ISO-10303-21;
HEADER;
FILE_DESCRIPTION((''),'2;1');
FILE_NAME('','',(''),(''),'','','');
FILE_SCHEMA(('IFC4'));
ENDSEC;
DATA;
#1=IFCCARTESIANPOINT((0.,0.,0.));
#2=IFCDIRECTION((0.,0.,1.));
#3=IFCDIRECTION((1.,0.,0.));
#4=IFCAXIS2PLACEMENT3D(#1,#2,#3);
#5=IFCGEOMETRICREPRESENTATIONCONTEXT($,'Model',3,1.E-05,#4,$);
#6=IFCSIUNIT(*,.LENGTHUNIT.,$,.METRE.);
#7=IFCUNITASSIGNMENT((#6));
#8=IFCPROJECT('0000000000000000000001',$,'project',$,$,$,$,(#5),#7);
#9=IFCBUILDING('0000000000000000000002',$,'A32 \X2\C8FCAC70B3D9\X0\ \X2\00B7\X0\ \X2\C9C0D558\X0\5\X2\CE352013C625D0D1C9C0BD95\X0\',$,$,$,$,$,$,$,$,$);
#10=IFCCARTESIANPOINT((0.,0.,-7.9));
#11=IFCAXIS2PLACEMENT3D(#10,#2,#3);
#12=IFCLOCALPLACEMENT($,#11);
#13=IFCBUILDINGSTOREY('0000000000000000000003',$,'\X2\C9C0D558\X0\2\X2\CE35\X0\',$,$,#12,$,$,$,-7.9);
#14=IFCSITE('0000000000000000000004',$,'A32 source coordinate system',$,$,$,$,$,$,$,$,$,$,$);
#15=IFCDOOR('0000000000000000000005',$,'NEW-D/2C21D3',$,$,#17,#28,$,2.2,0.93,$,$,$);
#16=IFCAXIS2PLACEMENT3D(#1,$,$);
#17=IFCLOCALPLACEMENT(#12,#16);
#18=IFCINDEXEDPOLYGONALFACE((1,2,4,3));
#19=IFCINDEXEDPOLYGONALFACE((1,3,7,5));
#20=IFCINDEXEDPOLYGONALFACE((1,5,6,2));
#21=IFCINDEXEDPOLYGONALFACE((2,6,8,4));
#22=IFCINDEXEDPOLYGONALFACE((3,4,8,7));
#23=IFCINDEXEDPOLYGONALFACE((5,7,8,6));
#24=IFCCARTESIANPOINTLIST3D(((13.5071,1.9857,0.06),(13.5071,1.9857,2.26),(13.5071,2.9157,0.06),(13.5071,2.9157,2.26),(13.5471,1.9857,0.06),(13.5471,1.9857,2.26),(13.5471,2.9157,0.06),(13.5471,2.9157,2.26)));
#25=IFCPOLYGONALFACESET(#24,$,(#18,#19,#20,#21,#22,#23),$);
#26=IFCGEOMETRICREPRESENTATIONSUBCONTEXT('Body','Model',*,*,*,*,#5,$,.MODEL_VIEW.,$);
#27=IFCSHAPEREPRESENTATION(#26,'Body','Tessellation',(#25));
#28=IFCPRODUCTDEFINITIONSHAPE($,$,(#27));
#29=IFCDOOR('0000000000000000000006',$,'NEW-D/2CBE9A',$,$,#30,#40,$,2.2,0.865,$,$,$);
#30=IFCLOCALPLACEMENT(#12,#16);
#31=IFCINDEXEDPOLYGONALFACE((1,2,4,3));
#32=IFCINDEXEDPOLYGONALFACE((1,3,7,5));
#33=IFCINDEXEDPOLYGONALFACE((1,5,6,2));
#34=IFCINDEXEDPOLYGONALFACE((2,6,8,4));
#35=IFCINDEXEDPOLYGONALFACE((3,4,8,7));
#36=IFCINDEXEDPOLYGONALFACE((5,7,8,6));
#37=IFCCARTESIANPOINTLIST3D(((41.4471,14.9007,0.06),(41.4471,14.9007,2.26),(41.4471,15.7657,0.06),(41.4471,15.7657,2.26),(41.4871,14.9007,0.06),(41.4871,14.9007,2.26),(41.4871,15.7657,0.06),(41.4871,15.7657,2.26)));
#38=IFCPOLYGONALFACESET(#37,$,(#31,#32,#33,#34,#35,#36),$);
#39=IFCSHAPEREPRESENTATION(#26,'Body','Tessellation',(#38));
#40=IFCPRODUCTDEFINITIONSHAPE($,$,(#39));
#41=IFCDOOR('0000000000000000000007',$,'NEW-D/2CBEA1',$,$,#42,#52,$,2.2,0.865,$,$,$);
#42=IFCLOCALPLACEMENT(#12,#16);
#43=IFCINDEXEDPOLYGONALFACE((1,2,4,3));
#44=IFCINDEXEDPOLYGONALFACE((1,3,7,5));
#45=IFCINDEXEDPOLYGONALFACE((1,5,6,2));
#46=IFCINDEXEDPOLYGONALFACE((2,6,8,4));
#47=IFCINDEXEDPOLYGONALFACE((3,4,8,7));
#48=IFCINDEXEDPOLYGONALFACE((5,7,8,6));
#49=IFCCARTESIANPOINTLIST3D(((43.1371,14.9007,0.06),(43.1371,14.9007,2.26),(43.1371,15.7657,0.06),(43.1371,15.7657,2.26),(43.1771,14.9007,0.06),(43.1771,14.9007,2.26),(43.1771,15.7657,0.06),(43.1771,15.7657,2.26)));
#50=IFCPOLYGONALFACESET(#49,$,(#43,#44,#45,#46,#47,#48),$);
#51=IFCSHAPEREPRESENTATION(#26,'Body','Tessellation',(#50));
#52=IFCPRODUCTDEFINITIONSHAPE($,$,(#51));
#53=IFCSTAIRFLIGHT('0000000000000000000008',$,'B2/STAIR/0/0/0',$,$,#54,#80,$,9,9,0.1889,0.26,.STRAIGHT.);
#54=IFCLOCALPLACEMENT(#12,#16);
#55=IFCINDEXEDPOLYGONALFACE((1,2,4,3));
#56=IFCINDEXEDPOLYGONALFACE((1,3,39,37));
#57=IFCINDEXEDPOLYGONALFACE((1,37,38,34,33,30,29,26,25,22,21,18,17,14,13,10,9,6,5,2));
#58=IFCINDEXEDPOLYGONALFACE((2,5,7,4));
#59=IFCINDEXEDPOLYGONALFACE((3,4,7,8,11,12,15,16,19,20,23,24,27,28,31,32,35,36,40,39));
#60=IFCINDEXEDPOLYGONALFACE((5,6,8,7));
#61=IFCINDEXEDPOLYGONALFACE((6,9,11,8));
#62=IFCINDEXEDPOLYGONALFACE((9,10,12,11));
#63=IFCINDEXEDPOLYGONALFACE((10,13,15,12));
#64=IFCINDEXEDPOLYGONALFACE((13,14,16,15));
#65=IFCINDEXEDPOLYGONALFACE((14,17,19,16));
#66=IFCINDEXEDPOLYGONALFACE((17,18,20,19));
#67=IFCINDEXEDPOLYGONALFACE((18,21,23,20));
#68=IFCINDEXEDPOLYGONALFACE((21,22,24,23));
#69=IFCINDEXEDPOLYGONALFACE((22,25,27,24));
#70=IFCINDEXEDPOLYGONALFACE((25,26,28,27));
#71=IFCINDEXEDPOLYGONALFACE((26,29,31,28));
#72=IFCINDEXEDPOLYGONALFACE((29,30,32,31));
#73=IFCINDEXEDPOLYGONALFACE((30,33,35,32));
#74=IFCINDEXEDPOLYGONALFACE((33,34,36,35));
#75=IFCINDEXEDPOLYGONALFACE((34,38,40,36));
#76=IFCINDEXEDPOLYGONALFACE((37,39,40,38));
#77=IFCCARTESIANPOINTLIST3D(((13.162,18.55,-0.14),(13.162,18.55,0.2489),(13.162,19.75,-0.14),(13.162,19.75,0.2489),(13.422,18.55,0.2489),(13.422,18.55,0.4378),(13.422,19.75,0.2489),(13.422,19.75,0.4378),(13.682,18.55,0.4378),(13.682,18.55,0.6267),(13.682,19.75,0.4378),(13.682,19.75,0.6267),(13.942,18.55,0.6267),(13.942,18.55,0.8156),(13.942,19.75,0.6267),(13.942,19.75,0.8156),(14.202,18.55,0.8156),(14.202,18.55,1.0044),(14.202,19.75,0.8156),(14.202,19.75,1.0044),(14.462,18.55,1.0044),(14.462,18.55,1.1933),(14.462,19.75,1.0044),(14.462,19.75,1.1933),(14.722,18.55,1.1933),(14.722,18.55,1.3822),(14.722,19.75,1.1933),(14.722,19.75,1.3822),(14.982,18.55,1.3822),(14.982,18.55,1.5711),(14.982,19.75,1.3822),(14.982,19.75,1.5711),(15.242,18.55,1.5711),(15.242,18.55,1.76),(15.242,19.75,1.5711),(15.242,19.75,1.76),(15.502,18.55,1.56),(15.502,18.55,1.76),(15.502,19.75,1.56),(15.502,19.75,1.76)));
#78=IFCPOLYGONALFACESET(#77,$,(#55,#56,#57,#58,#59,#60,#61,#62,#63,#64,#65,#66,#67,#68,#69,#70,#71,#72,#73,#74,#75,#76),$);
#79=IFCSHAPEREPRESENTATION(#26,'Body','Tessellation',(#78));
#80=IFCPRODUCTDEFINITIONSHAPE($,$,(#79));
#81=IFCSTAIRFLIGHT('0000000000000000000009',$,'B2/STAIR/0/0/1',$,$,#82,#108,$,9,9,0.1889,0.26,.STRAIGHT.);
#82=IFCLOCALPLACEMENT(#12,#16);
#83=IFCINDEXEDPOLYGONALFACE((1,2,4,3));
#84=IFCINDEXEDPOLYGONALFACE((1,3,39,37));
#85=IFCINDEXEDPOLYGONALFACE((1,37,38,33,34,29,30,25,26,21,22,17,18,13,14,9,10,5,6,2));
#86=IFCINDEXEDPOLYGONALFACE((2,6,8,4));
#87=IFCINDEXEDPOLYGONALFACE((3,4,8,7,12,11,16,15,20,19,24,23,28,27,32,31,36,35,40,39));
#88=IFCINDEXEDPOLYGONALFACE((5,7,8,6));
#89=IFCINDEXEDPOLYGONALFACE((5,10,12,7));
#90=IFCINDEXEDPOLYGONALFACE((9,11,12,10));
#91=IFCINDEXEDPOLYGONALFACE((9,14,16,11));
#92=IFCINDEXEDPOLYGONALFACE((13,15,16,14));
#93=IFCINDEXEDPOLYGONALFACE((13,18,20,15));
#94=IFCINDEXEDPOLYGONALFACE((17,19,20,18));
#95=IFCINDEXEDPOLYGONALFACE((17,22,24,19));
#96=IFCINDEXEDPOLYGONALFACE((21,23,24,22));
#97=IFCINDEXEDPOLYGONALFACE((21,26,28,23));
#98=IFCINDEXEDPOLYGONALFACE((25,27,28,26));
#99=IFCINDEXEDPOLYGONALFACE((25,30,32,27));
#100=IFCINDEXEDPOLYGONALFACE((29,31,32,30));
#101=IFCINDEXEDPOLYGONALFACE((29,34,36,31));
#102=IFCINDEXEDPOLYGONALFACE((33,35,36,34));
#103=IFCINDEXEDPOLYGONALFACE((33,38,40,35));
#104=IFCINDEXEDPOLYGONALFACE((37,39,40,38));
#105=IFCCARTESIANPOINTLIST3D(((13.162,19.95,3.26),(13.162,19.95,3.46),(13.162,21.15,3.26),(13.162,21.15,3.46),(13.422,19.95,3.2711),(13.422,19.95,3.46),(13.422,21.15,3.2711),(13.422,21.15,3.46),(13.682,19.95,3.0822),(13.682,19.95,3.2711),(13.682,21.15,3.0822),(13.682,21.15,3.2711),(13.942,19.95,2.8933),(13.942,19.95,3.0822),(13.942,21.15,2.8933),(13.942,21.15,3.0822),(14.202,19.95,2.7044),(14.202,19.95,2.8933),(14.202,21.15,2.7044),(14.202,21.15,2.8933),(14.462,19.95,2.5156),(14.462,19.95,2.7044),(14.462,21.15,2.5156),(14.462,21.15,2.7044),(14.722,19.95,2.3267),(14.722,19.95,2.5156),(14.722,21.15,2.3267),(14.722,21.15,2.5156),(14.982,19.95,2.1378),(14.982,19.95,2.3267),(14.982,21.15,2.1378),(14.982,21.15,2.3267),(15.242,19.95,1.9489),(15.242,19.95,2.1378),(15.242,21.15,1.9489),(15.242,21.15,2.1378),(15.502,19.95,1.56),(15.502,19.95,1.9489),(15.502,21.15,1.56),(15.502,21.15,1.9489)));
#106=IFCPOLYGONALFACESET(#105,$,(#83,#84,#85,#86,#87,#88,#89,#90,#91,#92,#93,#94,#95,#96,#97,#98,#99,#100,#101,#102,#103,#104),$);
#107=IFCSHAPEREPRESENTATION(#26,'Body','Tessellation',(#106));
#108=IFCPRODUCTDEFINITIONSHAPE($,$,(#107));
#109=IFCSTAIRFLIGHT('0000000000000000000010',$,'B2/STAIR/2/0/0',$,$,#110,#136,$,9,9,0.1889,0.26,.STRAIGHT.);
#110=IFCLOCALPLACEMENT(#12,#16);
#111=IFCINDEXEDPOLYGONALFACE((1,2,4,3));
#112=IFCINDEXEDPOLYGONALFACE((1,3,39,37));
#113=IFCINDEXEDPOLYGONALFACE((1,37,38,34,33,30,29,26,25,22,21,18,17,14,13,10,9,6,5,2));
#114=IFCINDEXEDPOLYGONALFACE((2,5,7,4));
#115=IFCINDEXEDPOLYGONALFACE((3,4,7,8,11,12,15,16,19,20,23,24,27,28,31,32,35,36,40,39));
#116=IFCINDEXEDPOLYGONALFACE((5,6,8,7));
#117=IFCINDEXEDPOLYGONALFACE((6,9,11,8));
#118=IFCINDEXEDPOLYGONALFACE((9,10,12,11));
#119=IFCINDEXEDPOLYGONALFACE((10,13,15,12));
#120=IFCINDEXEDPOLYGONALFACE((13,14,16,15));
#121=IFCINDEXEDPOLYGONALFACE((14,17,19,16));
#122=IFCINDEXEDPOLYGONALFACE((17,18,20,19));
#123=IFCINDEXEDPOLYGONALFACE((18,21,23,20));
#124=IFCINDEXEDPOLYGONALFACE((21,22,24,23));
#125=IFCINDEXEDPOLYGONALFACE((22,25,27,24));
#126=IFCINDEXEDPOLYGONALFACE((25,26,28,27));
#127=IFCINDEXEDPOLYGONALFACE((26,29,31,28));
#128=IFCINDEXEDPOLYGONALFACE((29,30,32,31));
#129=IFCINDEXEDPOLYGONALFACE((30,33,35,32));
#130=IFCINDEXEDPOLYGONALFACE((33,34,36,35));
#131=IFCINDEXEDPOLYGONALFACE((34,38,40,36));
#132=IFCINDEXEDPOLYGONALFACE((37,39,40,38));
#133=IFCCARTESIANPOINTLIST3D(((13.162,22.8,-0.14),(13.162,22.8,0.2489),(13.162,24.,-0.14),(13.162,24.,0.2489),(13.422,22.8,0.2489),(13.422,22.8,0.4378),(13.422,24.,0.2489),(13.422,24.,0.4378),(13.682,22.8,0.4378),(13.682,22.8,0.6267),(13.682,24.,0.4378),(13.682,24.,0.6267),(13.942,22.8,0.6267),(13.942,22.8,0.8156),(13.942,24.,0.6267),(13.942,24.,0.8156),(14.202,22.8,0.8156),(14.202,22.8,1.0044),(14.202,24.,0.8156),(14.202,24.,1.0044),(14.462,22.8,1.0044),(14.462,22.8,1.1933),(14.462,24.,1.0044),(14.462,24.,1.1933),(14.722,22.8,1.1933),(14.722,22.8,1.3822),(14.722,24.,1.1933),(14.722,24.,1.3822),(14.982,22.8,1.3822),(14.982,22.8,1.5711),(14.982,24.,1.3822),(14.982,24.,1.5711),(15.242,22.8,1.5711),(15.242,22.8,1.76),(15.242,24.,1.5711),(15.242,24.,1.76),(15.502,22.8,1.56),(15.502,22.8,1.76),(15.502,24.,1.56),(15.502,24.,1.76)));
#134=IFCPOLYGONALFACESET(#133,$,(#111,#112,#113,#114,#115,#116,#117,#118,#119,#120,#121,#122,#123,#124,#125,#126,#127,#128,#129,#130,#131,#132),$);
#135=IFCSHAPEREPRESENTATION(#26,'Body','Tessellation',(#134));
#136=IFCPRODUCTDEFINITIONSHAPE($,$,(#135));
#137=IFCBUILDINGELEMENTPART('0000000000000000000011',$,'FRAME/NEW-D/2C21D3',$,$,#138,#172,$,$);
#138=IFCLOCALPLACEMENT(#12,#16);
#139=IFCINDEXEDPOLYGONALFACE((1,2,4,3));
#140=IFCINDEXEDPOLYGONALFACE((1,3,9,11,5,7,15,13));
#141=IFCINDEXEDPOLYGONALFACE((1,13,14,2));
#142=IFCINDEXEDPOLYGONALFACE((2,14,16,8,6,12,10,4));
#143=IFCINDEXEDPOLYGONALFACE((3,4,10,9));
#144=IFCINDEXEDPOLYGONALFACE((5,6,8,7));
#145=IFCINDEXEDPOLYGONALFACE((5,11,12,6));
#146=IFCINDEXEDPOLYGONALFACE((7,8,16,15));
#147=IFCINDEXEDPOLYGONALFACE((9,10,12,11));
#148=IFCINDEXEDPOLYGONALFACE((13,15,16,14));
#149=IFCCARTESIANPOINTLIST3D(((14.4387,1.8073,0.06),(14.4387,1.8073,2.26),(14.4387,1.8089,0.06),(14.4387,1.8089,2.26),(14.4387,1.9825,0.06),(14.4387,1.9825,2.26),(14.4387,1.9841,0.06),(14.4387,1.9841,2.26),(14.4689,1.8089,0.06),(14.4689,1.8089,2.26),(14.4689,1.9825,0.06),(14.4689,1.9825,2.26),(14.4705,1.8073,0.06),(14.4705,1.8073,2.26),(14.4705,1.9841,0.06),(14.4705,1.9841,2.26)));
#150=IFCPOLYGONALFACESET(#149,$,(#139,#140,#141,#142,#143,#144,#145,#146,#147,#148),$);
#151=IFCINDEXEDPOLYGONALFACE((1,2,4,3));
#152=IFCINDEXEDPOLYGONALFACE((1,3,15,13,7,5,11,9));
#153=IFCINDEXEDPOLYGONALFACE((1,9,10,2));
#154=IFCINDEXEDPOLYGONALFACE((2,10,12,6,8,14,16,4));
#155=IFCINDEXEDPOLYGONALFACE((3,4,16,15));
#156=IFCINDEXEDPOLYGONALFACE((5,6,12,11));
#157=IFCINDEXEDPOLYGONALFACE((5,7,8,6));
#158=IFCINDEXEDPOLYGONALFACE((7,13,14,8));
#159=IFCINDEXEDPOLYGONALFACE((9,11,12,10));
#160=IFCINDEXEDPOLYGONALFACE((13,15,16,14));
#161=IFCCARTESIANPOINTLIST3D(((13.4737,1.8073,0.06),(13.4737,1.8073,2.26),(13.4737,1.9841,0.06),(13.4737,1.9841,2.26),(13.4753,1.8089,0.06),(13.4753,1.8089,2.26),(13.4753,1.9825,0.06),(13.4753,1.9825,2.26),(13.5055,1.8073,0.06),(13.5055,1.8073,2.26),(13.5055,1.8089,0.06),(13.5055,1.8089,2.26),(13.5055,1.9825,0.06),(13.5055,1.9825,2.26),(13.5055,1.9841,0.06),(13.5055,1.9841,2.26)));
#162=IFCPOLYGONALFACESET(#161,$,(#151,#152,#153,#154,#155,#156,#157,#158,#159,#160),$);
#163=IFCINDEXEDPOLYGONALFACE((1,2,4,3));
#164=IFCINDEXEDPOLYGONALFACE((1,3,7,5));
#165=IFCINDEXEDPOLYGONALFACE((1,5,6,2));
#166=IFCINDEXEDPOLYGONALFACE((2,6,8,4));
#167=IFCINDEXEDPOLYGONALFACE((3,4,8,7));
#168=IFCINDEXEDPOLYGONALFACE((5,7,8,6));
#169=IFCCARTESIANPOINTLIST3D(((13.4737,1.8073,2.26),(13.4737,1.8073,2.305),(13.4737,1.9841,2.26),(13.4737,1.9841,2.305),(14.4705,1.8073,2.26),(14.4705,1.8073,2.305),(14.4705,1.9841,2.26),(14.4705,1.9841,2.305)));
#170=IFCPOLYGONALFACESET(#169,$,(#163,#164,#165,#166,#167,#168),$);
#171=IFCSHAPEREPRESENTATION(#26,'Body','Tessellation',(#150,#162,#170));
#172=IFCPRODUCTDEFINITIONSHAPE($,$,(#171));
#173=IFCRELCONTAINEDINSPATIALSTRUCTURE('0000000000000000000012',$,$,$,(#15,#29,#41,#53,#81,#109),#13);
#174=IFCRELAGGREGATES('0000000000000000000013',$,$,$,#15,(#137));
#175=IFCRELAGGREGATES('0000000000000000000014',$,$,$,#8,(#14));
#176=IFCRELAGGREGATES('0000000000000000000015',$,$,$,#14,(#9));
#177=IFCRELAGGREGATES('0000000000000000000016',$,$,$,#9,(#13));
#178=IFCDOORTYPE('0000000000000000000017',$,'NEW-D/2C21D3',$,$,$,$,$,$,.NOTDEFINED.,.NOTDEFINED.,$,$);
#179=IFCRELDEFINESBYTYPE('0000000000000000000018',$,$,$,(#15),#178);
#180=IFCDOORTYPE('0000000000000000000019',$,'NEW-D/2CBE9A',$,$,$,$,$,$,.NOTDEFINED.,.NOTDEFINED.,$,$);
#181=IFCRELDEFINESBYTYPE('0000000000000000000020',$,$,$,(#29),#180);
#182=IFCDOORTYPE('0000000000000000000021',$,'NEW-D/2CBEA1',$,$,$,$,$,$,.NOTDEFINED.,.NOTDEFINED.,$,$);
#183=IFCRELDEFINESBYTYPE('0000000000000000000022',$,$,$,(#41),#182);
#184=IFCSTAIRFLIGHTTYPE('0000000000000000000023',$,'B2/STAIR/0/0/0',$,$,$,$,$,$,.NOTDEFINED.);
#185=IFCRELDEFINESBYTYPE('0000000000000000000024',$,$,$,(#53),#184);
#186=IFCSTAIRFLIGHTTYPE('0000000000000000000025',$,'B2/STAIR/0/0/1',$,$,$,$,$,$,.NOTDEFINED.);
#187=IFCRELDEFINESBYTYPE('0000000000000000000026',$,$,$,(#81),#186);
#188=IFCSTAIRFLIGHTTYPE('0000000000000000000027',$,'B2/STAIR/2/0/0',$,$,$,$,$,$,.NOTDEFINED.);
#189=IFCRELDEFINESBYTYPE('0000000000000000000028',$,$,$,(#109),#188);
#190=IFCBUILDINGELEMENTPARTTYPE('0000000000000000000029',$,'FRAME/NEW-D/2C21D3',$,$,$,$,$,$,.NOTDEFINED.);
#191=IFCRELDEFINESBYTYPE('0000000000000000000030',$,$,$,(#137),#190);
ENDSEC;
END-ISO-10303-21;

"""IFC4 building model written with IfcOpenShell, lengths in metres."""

from ifc_helpers import new_model, si_unit, frame, origin, origin_with_axes, place, context, subcontext, project, spatial, polyline, outline, extrude, source, transform, mapped, type_object, type_shapes, element, aggregate, save


model = new_model("IFC4")

# Units and contexts
model_context = context("Model", 3, precision=1e-05, world=origin_with_axes())
body_context = subcontext(model_context, "Body", "Model", "MODEL_VIEW")
ifc_project = project(units=[si_unit("LENGTHUNIT", "METRE")], contexts=[model_context])

# Site, building, storey
site = spatial("IfcSite", under=ifc_project, Name="A32 source coordinate system")
building = spatial("IfcBuilding", under=site, Name="A32 주거동 · 지하5층–옥탑지붕")
storey_placement = place(None, frame((0.0, 0.0, -7.9), z_axis=(0.0, 0.0, 1.0), x_axis=(1.0, 0.0, 0.0)))
storey = spatial("IfcBuildingStorey", under=building, at=storey_placement, Name="지하2층", Elevation=-7.9)

# Door
door_type_1 = type_object("IfcDoorType", Name="NEW-D/2C21D3", OperationType="NOTDEFINED", PredefinedType="NOTDEFINED")
shared_shape_1 = source(origin(), body_context, "Body", "SweptSolid", [
    extrude(outline(polyline([(13.5471, 2.9157), (13.5471, 1.9857), (13.5071, 1.9857), (13.5071, 2.9157), (13.5471, 2.9157)])), frame((0.0, 0.0, 0.06)), (0.0, 0.0, 1.0), 2.2),
])
type_shapes(door_type_1, [shared_shape_1])
door_1_placement = place(storey_placement, origin_with_axes())
door_1 = element("IfcDoor", 1, at=door_1_placement, inside=storey, type_object=door_type_1, Name="NEW-D/2C21D3", OverallHeight=2.2, OverallWidth=0.93, context=body_context, shape_type="MappedRepresentation", body=[
    mapped(shared_shape_1, transform((0.0, 0.0, 0.0), scale=1.0)),
])

# Doors
door_type_2 = type_object("IfcDoorType", Name="NEW-D/2CBE9A", OperationType="NOTDEFINED", PredefinedType="NOTDEFINED")
shared_shape_2 = source(origin(), body_context, "Body", "SweptSolid", [
    extrude(outline(polyline([(41.4871, 14.9007), (41.4471, 14.9007), (41.4471, 15.7657), (41.4871, 15.7657), (41.4871, 14.9007)])), frame((0.0, 0.0, 0.06)), (0.0, 0.0, 1.0), 2.2),
])
type_shapes(door_type_2, [shared_shape_2])
door_2_placement = place(storey_placement, origin_with_axes())
element("IfcDoor", 2, at=door_2_placement, inside=storey, type_object=door_type_2, Name="NEW-D/2CBE9A", OverallHeight=2.2, OverallWidth=0.865, context=body_context, shape_type="MappedRepresentation", body=[
    mapped(shared_shape_2, transform((0.0, 0.0, 0.0), scale=1.0)),
])
door_type_3 = type_object("IfcDoorType", Name="NEW-D/2CBEA1", OperationType="NOTDEFINED", PredefinedType="NOTDEFINED")
shared_shape_3 = source(origin(), body_context, "Body", "SweptSolid", [
    extrude(outline(polyline([(43.1771, 15.7657), (43.1771, 14.9007), (43.1371, 14.9007), (43.1371, 15.7657), (43.1771, 15.7657)])), frame((0.0, 0.0, 0.06)), (0.0, 0.0, 1.0), 2.2),
])
type_shapes(door_type_3, [shared_shape_3])
door_3_placement = place(storey_placement, origin_with_axes())
element("IfcDoor", 3, at=door_3_placement, inside=storey, type_object=door_type_3, Name="NEW-D/2CBEA1", OverallHeight=2.2, OverallWidth=0.865, context=body_context, shape_type="MappedRepresentation", body=[
    mapped(shared_shape_3, transform((0.0, 0.0, 0.0), scale=1.0)),
])

# Stair flights
stair_flight_type_1 = type_object("IfcStairFlightType", Name="B2/STAIR/0/0/0", PredefinedType="NOTDEFINED")
shared_shape_4 = source(origin(), body_context, "Body", "SweptSolid", [
    extrude(outline(polyline([(0.0, -0.14), (2.34, 1.56), (2.34, 1.76), (2.08, 1.76), (2.08, 1.5711), (1.82, 1.5711), (1.82, 1.3822), (1.56, 1.3822), (1.56, 1.1933), (1.3, 1.1933), (1.3, 1.0044), (1.04, 1.0044), (1.04, 0.8156), (0.78, 0.8156), (0.78, 0.6267), (0.52, 0.6267), (0.52, 0.4378), (0.26, 0.4378), (0.26, 0.2489), (0.0, 0.2489), (0.0, -0.14)])), frame((13.162, 19.75, 0.0), z_axis=(0.0, -1.0, 0.0), x_axis=(1.0, 0.0, 0.0)), (0.0, 0.0, 1.0), 1.2),
])
type_shapes(stair_flight_type_1, [shared_shape_4])
stair_flight_1_placement = place(storey_placement, origin_with_axes())
element("IfcStairFlight", 4, at=stair_flight_1_placement, inside=storey, type_object=stair_flight_type_1, Name="B2/STAIR/0/0/0", NumberOfRisers=9, NumberOfTreads=9, PredefinedType="STRAIGHT", RiserHeight=0.1889, TreadLength=0.26, context=body_context, shape_type="MappedRepresentation", body=[
    mapped(shared_shape_4, transform((0.0, 0.0, 0.0), scale=1.0)),
])
stair_flight_type_2 = type_object("IfcStairFlightType", Name="B2/STAIR/0/0/1", PredefinedType="NOTDEFINED")
shared_shape_5 = source(origin(), body_context, "Body", "SweptSolid", [
    extrude(outline(polyline([(0.0, 1.56), (2.34, 3.26), (2.34, 3.46), (2.08, 3.46), (2.08, 3.2711), (1.82, 3.2711), (1.82, 3.0822), (1.56, 3.0822), (1.56, 2.8933), (1.3, 2.8933), (1.3, 2.7044), (1.04, 2.7044), (1.04, 2.5156), (0.78, 2.5156), (0.78, 2.3267), (0.52, 2.3267), (0.52, 2.1378), (0.26, 2.1378), (0.26, 1.9489), (0.0, 1.9489), (0.0, 1.56)])), frame((15.502, 19.95, 0.0), z_axis=(0.0, 1.0, 0.0), x_axis=(-1.0, 0.0, 0.0)), (0.0, 0.0, 1.0), 1.2),
])
type_shapes(stair_flight_type_2, [shared_shape_5])
stair_flight_2_placement = place(storey_placement, origin_with_axes())
element("IfcStairFlight", 5, at=stair_flight_2_placement, inside=storey, type_object=stair_flight_type_2, Name="B2/STAIR/0/0/1", NumberOfRisers=9, NumberOfTreads=9, PredefinedType="STRAIGHT", RiserHeight=0.1889, TreadLength=0.26, context=body_context, shape_type="MappedRepresentation", body=[
    mapped(shared_shape_5, transform((0.0, 0.0, 0.0), scale=1.0)),
])
stair_flight_type_3 = type_object("IfcStairFlightType", Name="B2/STAIR/2/0/0", PredefinedType="NOTDEFINED")
shared_shape_6 = source(origin(), body_context, "Body", "SweptSolid", [
    extrude(outline(polyline([(0.0, -0.14), (2.34, 1.56), (2.34, 1.76), (2.08, 1.76), (2.08, 1.5711), (1.82, 1.5711), (1.82, 1.3822), (1.56, 1.3822), (1.56, 1.1933), (1.3, 1.1933), (1.3, 1.0044), (1.04, 1.0044), (1.04, 0.8156), (0.78, 0.8156), (0.78, 0.6267), (0.52, 0.6267), (0.52, 0.4378), (0.26, 0.4378), (0.26, 0.2489), (0.0, 0.2489), (0.0, -0.14)])), frame((13.162, 24.0, 0.0), z_axis=(0.0, -1.0, 0.0), x_axis=(1.0, 0.0, 0.0)), (0.0, 0.0, 1.0), 1.2),
])
type_shapes(stair_flight_type_3, [shared_shape_6])
stair_flight_3_placement = place(storey_placement, origin_with_axes())
element("IfcStairFlight", 6, at=stair_flight_3_placement, inside=storey, type_object=stair_flight_type_3, Name="B2/STAIR/2/0/0", NumberOfRisers=9, NumberOfTreads=9, PredefinedType="STRAIGHT", RiserHeight=0.1889, TreadLength=0.26, context=body_context, shape_type="MappedRepresentation", body=[
    mapped(shared_shape_6, transform((0.0, 0.0, 0.0), scale=1.0)),
])

# Building element part
building_element_part_type_1 = type_object("IfcBuildingElementPartType", Name="FRAME/NEW-D/2C21D3", PredefinedType="NOTDEFINED")
shared_shape_7 = source(origin(), body_context, "Body", "SweptSolid", [
    extrude(outline(polyline([(14.4705, 1.8073), (14.4387, 1.8073), (14.4387, 1.8089), (14.4689, 1.8089), (14.4689, 1.9825), (14.4387, 1.9825), (14.4387, 1.9841), (14.4705, 1.9841), (14.4705, 1.8073)])), frame((0.0, 0.0, 0.06)), (0.0, 0.0, 1.0), 2.2),
    extrude(outline(polyline([(13.4753, 1.9825), (13.4753, 1.8089), (13.5055, 1.8089), (13.5055, 1.8073), (13.4737, 1.8073), (13.4737, 1.9841), (13.5055, 1.9841), (13.5055, 1.9825), (13.4753, 1.9825)])), frame((0.0, 0.0, 0.06)), (0.0, 0.0, 1.0), 2.2),
    extrude(outline(polyline([(14.4705, 1.8073), (14.4705, 1.9841), (13.4737, 1.9841), (13.4737, 1.8073), (14.4705, 1.8073)])), frame((0.0, 0.0, 2.26)), (0.0, 0.0, 1.0), 0.045),
])
type_shapes(building_element_part_type_1, [shared_shape_7])
building_element_part_1_placement = place(door_1_placement, origin_with_axes())
building_element_part_1 = element("IfcBuildingElementPart", 7, at=building_element_part_1_placement, type_object=building_element_part_type_1, Name="FRAME/NEW-D/2C21D3", context=body_context, shape_type="MappedRepresentation", body=[
    mapped(shared_shape_7, transform((0.0, 0.0, 0.0), scale=1.0)),
])
aggregate(door_1, [building_element_part_1])

save(model, "model.ifc")
